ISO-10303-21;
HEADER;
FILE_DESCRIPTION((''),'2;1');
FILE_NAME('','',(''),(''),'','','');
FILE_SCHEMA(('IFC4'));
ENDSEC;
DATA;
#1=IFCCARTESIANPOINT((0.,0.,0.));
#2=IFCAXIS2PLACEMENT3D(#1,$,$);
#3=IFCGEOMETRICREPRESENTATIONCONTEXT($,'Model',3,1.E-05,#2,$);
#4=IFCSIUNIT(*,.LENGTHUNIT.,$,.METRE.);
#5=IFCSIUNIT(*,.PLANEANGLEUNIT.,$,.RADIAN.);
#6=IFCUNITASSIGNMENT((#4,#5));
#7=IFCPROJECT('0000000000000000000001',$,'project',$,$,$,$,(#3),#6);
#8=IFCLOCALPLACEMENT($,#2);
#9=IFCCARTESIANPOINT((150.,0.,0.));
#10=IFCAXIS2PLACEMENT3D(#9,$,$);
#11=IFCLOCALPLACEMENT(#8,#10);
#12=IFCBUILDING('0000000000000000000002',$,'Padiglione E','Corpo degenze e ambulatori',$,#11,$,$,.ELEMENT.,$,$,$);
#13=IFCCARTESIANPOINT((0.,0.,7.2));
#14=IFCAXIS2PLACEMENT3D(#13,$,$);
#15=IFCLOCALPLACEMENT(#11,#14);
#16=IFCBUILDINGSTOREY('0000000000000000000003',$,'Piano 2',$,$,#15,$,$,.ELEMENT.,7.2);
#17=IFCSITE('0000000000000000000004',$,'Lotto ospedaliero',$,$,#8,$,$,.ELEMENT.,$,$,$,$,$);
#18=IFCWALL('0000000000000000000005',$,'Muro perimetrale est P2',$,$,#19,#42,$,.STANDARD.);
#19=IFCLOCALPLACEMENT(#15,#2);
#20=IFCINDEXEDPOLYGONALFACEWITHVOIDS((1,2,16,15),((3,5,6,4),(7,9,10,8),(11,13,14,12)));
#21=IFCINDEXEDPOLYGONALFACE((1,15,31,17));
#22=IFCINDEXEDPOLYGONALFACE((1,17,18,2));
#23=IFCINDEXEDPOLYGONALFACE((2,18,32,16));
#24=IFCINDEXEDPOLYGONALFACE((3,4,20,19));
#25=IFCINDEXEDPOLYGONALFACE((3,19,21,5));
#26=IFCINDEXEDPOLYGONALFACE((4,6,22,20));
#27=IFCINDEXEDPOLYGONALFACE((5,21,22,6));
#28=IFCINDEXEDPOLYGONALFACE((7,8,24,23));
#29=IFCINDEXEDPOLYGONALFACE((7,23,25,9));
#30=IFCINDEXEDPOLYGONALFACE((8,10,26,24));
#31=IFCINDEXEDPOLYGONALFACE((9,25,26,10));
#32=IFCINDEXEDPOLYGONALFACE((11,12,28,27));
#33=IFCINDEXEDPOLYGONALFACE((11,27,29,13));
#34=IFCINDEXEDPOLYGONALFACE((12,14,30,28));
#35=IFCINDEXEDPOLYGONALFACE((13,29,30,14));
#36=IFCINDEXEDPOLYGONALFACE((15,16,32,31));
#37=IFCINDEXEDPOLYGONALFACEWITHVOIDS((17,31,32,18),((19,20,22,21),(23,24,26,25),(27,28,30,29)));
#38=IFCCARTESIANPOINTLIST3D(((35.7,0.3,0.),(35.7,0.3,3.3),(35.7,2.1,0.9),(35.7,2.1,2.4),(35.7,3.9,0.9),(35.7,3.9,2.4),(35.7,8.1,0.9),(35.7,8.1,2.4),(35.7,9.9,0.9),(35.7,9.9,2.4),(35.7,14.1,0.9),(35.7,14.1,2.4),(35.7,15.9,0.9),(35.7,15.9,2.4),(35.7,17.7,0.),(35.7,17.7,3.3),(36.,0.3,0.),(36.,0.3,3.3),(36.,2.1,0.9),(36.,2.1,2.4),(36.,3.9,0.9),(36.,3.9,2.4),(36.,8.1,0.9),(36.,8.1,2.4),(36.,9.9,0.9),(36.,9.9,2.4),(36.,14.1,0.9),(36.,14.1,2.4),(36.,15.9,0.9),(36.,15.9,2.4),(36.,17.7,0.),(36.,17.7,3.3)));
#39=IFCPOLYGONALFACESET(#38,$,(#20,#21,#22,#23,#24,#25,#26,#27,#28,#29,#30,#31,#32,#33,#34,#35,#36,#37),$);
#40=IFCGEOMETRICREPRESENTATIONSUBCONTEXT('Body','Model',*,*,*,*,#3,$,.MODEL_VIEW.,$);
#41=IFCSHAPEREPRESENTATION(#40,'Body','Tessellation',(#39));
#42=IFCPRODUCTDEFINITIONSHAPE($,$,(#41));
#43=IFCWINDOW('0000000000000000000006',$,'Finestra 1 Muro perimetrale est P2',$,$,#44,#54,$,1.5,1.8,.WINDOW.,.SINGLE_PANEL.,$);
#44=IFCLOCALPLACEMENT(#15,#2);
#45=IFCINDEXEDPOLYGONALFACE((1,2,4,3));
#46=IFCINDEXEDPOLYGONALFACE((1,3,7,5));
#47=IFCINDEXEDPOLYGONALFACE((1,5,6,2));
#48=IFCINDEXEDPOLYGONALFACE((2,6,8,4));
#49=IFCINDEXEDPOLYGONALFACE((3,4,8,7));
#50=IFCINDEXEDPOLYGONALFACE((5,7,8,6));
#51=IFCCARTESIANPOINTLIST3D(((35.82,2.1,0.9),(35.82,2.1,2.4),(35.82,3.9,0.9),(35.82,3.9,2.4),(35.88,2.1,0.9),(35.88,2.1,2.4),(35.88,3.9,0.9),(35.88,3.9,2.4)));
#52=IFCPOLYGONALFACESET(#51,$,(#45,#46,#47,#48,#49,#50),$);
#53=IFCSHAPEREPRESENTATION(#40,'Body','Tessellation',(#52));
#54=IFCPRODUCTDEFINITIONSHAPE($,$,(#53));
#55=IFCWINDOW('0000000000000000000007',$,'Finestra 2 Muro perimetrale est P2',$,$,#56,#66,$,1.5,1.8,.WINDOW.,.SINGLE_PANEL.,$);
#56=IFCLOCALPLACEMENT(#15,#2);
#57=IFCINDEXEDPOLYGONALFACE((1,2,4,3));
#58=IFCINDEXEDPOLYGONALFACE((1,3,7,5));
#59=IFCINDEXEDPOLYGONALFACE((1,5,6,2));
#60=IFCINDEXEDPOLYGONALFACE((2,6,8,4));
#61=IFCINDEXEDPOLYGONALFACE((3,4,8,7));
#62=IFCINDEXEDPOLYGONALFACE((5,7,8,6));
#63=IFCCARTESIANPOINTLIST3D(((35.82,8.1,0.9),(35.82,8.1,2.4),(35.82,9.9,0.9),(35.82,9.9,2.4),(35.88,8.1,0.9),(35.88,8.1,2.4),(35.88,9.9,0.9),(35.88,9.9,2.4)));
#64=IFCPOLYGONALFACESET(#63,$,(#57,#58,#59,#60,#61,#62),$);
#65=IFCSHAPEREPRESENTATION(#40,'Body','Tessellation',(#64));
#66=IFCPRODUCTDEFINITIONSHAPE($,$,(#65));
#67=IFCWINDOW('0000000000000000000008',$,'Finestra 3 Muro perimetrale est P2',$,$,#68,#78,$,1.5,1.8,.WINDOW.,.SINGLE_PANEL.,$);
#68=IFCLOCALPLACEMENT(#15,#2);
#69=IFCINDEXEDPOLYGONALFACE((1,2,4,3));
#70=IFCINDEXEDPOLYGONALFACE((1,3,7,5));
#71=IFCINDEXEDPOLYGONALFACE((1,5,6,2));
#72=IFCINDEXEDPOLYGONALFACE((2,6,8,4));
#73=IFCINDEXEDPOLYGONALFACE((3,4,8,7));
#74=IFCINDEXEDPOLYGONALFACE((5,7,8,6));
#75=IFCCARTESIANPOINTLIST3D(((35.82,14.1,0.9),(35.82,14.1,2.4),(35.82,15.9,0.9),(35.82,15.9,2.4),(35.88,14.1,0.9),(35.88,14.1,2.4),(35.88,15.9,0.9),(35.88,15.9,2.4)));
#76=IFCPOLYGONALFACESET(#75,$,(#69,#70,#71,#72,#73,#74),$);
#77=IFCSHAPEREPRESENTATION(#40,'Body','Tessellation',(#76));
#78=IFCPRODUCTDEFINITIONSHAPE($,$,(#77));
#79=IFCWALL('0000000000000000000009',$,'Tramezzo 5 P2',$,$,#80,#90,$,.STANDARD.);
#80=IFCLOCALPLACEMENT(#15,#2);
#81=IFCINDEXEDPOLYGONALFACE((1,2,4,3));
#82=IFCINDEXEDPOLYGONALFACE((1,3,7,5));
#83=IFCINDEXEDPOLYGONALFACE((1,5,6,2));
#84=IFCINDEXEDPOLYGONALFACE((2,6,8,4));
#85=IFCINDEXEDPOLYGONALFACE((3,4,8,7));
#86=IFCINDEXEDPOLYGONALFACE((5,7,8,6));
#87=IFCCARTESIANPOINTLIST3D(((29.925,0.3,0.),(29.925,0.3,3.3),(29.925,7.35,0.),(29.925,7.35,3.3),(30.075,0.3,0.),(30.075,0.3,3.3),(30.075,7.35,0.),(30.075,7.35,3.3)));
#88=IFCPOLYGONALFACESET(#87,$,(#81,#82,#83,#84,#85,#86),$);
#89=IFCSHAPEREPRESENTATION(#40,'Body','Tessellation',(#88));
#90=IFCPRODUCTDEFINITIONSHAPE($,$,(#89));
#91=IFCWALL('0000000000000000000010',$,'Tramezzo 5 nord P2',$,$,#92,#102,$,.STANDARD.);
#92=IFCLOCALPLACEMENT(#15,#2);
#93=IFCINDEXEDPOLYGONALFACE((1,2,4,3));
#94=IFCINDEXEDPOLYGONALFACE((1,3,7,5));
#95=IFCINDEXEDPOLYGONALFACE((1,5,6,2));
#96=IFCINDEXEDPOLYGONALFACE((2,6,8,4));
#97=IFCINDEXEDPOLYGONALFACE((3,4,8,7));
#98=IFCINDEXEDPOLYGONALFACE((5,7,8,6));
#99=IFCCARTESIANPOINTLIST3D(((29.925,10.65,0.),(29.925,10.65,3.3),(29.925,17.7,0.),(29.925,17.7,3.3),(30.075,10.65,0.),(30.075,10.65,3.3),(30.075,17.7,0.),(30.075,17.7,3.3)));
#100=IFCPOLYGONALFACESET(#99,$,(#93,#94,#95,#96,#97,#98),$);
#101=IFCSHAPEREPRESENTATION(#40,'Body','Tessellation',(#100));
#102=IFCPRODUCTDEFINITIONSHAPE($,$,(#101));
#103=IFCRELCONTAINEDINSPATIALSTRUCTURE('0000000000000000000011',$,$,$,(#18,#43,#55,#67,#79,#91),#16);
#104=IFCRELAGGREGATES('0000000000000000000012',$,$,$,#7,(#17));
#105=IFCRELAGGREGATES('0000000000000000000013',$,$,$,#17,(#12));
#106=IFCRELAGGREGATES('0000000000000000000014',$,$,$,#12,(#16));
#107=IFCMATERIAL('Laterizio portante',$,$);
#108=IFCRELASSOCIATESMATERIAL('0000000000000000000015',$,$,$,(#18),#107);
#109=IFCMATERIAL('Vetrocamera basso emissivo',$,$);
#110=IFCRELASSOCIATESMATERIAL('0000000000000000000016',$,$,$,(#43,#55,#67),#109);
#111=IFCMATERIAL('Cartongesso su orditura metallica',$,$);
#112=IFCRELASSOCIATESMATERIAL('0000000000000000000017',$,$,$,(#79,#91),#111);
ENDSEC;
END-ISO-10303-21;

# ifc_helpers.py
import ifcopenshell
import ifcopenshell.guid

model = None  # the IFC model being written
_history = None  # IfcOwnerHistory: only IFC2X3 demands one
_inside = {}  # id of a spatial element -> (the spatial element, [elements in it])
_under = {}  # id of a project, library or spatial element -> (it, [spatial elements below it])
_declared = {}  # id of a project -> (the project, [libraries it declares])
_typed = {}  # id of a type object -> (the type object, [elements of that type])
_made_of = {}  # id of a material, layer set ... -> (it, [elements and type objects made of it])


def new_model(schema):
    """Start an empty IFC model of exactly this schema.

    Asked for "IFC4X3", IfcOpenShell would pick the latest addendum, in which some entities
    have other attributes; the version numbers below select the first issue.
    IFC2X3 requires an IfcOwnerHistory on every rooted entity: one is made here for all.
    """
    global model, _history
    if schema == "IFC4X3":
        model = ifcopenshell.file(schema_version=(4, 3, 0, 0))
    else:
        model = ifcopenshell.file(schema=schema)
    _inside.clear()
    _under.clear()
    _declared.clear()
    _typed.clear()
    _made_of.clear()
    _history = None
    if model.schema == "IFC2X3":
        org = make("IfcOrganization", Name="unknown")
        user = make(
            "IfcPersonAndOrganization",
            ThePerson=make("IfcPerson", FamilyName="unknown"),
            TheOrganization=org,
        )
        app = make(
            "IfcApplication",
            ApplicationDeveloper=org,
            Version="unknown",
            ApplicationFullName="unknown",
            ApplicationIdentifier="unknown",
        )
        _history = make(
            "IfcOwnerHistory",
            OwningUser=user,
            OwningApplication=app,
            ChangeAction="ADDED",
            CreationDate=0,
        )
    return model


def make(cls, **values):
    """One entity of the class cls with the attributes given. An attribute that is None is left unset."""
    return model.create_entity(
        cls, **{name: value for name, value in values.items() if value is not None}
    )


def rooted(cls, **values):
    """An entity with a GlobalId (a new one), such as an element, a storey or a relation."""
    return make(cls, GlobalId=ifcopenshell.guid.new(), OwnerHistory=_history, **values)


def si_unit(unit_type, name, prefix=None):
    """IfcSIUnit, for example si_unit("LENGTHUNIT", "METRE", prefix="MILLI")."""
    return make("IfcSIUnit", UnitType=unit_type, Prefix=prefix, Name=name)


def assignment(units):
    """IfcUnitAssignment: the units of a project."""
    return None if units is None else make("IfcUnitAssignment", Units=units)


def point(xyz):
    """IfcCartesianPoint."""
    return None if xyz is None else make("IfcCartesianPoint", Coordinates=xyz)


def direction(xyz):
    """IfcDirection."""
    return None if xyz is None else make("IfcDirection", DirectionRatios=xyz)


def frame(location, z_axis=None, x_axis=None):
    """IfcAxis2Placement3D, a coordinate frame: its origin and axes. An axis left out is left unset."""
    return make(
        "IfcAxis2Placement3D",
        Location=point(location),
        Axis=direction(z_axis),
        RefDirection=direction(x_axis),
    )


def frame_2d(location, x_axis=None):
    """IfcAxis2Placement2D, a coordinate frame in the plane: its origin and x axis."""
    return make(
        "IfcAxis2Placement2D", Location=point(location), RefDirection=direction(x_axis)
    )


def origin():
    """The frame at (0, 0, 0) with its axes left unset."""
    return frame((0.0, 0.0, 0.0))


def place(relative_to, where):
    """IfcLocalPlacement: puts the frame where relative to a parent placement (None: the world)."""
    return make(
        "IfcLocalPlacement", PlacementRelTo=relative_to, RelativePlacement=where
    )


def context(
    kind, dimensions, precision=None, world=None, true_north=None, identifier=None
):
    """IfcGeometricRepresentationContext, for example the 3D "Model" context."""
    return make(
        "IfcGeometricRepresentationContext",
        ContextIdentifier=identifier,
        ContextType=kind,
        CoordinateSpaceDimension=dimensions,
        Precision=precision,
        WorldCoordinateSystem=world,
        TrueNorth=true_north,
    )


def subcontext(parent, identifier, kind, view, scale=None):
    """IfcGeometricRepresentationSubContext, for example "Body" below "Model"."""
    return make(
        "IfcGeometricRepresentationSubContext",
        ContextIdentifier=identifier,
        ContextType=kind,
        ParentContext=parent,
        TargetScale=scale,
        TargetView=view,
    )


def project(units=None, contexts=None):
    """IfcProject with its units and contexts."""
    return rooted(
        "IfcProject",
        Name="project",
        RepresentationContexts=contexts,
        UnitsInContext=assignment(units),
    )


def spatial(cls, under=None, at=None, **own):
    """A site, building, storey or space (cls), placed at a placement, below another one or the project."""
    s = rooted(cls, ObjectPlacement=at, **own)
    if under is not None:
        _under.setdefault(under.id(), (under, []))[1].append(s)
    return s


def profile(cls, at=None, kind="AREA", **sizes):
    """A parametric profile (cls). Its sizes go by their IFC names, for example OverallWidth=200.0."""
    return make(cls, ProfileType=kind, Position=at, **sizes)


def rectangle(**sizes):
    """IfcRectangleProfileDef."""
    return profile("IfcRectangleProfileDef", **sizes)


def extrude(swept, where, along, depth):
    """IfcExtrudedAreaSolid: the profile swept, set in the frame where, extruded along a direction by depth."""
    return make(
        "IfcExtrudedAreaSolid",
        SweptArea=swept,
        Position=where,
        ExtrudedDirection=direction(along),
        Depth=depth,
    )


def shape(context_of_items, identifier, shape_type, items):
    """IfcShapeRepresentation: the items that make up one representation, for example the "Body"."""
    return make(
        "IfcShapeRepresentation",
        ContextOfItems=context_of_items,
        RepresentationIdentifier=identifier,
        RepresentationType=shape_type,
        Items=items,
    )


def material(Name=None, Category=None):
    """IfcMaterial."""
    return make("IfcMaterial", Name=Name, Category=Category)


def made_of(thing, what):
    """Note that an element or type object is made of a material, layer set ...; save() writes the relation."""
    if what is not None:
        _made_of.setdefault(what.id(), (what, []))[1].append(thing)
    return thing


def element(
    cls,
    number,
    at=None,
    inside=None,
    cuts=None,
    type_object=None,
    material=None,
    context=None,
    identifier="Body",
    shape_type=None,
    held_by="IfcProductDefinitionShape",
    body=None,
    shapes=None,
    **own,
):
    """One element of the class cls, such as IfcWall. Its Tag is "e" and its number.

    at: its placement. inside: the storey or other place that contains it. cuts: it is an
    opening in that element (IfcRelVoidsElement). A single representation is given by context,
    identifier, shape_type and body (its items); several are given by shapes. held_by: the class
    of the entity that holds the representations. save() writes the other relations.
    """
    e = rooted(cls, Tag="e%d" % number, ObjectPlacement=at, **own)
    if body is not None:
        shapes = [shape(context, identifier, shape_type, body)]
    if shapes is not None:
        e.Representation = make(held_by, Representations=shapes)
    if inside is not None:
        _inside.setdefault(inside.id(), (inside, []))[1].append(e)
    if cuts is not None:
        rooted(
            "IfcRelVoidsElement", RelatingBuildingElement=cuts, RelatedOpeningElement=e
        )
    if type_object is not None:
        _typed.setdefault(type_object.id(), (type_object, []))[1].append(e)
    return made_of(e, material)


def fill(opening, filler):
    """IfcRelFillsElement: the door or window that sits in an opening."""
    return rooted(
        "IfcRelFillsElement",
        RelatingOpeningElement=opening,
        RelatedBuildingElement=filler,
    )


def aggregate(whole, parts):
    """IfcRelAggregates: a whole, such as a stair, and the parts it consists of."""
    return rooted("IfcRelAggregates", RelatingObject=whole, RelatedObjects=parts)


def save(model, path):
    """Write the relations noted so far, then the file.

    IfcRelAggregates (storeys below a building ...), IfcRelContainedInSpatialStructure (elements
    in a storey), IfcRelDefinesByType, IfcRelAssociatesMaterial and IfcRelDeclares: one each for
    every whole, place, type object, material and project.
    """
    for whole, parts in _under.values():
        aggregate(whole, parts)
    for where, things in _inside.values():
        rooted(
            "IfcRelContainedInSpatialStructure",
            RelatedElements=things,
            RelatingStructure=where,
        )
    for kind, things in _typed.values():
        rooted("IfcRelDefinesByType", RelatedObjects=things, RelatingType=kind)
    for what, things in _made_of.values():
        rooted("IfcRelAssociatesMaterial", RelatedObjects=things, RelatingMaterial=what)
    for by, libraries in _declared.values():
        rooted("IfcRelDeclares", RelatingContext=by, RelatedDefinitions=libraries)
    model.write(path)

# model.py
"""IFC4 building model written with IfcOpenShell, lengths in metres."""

from ifc_helpers import new_model, si_unit, frame, frame_2d, origin, place, context, subcontext, project, spatial, rectangle, extrude, material, element, fill, save


model = new_model("IFC4")

# Units and contexts
model_context = context("Model", 3, precision=1e-05, world=origin())
body_context = subcontext(model_context, "Body", "Model", "MODEL_VIEW")
ifc_project = project(units=[si_unit("LENGTHUNIT", "METRE"), si_unit("PLANEANGLEUNIT", "RADIAN")], contexts=[model_context])

# Site, building, storey
site_placement = place(None, origin())
site = spatial("IfcSite", under=ifc_project, at=site_placement, Name="Lotto ospedaliero", CompositionType="ELEMENT")
building_placement = place(site_placement, frame((150.0, 0.0, 0.0)))
building = spatial("IfcBuilding", under=site, at=building_placement, Name="Padiglione E", Description="Corpo degenze e ambulatori", CompositionType="ELEMENT")
storey_placement = place(building_placement, frame((0.0, 0.0, 7.2)))
storey = spatial("IfcBuildingStorey", under=building, at=storey_placement, Name="Piano 2", CompositionType="ELEMENT", Elevation=7.2)

# Wall, openings, windows
ifc_material_1 = material(Name="Laterizio portante")
wall_placement = place(storey_placement, frame((35.7, 0.3, 0.0)))
wall = element("IfcWall", 1, at=wall_placement, inside=storey, material=ifc_material_1, Name="Muro perimetrale est P2", PredefinedType="STANDARD", context=body_context, shape_type="SweptSolid", body=[
    extrude(rectangle(XDim=0.3, YDim=17.4, at=frame_2d((0.15, 8.7))), origin(), (0.0, 0.0, 1.0), 3.3),
])
opening_1_placement = place(wall_placement, frame((-0.1, 1.8, 0.9)))
opening_1 = element("IfcOpeningElement", 2, at=opening_1_placement, cuts=wall, PredefinedType="OPENING", context=body_context, shape_type="SweptSolid", body=[
    extrude(rectangle(XDim=0.5, YDim=1.8, at=frame_2d((0.25, 0.9))), origin(), (0.0, 0.0, 1.0), 1.5),
])
opening_2_placement = place(wall_placement, frame((-0.1, 7.8, 0.9)))
opening_2 = element("IfcOpeningElement", 3, at=opening_2_placement, cuts=wall, PredefinedType="OPENING", context=body_context, shape_type="SweptSolid", body=[
    extrude(rectangle(XDim=0.5, YDim=1.8, at=frame_2d((0.25, 0.9))), origin(), (0.0, 0.0, 1.0), 1.5),
])
opening_3_placement = place(wall_placement, frame((-0.1, 13.8, 0.9)))
opening_3 = element("IfcOpeningElement", 4, at=opening_3_placement, cuts=wall, PredefinedType="OPENING", context=body_context, shape_type="SweptSolid", body=[
    extrude(rectangle(XDim=0.5, YDim=1.8, at=frame_2d((0.25, 0.9))), origin(), (0.0, 0.0, 1.0), 1.5),
])
ifc_material_2 = material(Name="Vetrocamera basso emissivo")
window_1_placement = place(wall_placement, frame((0.12, 1.8, 0.9)))
window_1 = element("IfcWindow", 5, at=window_1_placement, inside=storey, material=ifc_material_2, Name="Finestra 1 Muro perimetrale est P2", OverallHeight=1.5, OverallWidth=1.8, PartitioningType="SINGLE_PANEL", PredefinedType="WINDOW", context=body_context, shape_type="SweptSolid", body=[
    extrude(rectangle(XDim=0.06, YDim=1.8, at=frame_2d((0.03, 0.9))), origin(), (0.0, 0.0, 1.0), 1.5),
])
fill(opening_1, window_1)
window_2_placement = place(wall_placement, frame((0.12, 7.8, 0.9)))
window_2 = element("IfcWindow", 6, at=window_2_placement, inside=storey, material=ifc_material_2, Name="Finestra 2 Muro perimetrale est P2", OverallHeight=1.5, OverallWidth=1.8, PartitioningType="SINGLE_PANEL", PredefinedType="WINDOW", context=body_context, shape_type="SweptSolid", body=[
    extrude(rectangle(XDim=0.06, YDim=1.8, at=frame_2d((0.03, 0.9))), origin(), (0.0, 0.0, 1.0), 1.5),
])
fill(opening_2, window_2)
window_3_placement = place(wall_placement, frame((0.12, 13.8, 0.9)))
window_3 = element("IfcWindow", 7, at=window_3_placement, inside=storey, material=ifc_material_2, Name="Finestra 3 Muro perimetrale est P2", OverallHeight=1.5, OverallWidth=1.8, PartitioningType="SINGLE_PANEL", PredefinedType="WINDOW", context=body_context, shape_type="SweptSolid", body=[
    extrude(rectangle(XDim=0.06, YDim=1.8, at=frame_2d((0.03, 0.9))), origin(), (0.0, 0.0, 1.0), 1.5),
])
fill(opening_3, window_3)

# Walls
ifc_material_3 = material(Name="Cartongesso su orditura metallica")
for number, where, name in (
    (8, (29.925, 0.3, 0.0), "Tramezzo 5 P2"),
    (9, (29.925, 10.65, 0.0), "Tramezzo 5 nord P2"),
):
    element("IfcWall", number, at=place(storey_placement, frame(where)), inside=storey, material=ifc_material_3, Name=name, PredefinedType="STANDARD", context=body_context, shape_type="SweptSolid", body=[
        extrude(rectangle(XDim=0.15, YDim=7.05, at=frame_2d((0.075, 3.525))), origin(), (0.0, 0.0, 1.0), 3.3),
    ])

save(model, "model.ifc")
